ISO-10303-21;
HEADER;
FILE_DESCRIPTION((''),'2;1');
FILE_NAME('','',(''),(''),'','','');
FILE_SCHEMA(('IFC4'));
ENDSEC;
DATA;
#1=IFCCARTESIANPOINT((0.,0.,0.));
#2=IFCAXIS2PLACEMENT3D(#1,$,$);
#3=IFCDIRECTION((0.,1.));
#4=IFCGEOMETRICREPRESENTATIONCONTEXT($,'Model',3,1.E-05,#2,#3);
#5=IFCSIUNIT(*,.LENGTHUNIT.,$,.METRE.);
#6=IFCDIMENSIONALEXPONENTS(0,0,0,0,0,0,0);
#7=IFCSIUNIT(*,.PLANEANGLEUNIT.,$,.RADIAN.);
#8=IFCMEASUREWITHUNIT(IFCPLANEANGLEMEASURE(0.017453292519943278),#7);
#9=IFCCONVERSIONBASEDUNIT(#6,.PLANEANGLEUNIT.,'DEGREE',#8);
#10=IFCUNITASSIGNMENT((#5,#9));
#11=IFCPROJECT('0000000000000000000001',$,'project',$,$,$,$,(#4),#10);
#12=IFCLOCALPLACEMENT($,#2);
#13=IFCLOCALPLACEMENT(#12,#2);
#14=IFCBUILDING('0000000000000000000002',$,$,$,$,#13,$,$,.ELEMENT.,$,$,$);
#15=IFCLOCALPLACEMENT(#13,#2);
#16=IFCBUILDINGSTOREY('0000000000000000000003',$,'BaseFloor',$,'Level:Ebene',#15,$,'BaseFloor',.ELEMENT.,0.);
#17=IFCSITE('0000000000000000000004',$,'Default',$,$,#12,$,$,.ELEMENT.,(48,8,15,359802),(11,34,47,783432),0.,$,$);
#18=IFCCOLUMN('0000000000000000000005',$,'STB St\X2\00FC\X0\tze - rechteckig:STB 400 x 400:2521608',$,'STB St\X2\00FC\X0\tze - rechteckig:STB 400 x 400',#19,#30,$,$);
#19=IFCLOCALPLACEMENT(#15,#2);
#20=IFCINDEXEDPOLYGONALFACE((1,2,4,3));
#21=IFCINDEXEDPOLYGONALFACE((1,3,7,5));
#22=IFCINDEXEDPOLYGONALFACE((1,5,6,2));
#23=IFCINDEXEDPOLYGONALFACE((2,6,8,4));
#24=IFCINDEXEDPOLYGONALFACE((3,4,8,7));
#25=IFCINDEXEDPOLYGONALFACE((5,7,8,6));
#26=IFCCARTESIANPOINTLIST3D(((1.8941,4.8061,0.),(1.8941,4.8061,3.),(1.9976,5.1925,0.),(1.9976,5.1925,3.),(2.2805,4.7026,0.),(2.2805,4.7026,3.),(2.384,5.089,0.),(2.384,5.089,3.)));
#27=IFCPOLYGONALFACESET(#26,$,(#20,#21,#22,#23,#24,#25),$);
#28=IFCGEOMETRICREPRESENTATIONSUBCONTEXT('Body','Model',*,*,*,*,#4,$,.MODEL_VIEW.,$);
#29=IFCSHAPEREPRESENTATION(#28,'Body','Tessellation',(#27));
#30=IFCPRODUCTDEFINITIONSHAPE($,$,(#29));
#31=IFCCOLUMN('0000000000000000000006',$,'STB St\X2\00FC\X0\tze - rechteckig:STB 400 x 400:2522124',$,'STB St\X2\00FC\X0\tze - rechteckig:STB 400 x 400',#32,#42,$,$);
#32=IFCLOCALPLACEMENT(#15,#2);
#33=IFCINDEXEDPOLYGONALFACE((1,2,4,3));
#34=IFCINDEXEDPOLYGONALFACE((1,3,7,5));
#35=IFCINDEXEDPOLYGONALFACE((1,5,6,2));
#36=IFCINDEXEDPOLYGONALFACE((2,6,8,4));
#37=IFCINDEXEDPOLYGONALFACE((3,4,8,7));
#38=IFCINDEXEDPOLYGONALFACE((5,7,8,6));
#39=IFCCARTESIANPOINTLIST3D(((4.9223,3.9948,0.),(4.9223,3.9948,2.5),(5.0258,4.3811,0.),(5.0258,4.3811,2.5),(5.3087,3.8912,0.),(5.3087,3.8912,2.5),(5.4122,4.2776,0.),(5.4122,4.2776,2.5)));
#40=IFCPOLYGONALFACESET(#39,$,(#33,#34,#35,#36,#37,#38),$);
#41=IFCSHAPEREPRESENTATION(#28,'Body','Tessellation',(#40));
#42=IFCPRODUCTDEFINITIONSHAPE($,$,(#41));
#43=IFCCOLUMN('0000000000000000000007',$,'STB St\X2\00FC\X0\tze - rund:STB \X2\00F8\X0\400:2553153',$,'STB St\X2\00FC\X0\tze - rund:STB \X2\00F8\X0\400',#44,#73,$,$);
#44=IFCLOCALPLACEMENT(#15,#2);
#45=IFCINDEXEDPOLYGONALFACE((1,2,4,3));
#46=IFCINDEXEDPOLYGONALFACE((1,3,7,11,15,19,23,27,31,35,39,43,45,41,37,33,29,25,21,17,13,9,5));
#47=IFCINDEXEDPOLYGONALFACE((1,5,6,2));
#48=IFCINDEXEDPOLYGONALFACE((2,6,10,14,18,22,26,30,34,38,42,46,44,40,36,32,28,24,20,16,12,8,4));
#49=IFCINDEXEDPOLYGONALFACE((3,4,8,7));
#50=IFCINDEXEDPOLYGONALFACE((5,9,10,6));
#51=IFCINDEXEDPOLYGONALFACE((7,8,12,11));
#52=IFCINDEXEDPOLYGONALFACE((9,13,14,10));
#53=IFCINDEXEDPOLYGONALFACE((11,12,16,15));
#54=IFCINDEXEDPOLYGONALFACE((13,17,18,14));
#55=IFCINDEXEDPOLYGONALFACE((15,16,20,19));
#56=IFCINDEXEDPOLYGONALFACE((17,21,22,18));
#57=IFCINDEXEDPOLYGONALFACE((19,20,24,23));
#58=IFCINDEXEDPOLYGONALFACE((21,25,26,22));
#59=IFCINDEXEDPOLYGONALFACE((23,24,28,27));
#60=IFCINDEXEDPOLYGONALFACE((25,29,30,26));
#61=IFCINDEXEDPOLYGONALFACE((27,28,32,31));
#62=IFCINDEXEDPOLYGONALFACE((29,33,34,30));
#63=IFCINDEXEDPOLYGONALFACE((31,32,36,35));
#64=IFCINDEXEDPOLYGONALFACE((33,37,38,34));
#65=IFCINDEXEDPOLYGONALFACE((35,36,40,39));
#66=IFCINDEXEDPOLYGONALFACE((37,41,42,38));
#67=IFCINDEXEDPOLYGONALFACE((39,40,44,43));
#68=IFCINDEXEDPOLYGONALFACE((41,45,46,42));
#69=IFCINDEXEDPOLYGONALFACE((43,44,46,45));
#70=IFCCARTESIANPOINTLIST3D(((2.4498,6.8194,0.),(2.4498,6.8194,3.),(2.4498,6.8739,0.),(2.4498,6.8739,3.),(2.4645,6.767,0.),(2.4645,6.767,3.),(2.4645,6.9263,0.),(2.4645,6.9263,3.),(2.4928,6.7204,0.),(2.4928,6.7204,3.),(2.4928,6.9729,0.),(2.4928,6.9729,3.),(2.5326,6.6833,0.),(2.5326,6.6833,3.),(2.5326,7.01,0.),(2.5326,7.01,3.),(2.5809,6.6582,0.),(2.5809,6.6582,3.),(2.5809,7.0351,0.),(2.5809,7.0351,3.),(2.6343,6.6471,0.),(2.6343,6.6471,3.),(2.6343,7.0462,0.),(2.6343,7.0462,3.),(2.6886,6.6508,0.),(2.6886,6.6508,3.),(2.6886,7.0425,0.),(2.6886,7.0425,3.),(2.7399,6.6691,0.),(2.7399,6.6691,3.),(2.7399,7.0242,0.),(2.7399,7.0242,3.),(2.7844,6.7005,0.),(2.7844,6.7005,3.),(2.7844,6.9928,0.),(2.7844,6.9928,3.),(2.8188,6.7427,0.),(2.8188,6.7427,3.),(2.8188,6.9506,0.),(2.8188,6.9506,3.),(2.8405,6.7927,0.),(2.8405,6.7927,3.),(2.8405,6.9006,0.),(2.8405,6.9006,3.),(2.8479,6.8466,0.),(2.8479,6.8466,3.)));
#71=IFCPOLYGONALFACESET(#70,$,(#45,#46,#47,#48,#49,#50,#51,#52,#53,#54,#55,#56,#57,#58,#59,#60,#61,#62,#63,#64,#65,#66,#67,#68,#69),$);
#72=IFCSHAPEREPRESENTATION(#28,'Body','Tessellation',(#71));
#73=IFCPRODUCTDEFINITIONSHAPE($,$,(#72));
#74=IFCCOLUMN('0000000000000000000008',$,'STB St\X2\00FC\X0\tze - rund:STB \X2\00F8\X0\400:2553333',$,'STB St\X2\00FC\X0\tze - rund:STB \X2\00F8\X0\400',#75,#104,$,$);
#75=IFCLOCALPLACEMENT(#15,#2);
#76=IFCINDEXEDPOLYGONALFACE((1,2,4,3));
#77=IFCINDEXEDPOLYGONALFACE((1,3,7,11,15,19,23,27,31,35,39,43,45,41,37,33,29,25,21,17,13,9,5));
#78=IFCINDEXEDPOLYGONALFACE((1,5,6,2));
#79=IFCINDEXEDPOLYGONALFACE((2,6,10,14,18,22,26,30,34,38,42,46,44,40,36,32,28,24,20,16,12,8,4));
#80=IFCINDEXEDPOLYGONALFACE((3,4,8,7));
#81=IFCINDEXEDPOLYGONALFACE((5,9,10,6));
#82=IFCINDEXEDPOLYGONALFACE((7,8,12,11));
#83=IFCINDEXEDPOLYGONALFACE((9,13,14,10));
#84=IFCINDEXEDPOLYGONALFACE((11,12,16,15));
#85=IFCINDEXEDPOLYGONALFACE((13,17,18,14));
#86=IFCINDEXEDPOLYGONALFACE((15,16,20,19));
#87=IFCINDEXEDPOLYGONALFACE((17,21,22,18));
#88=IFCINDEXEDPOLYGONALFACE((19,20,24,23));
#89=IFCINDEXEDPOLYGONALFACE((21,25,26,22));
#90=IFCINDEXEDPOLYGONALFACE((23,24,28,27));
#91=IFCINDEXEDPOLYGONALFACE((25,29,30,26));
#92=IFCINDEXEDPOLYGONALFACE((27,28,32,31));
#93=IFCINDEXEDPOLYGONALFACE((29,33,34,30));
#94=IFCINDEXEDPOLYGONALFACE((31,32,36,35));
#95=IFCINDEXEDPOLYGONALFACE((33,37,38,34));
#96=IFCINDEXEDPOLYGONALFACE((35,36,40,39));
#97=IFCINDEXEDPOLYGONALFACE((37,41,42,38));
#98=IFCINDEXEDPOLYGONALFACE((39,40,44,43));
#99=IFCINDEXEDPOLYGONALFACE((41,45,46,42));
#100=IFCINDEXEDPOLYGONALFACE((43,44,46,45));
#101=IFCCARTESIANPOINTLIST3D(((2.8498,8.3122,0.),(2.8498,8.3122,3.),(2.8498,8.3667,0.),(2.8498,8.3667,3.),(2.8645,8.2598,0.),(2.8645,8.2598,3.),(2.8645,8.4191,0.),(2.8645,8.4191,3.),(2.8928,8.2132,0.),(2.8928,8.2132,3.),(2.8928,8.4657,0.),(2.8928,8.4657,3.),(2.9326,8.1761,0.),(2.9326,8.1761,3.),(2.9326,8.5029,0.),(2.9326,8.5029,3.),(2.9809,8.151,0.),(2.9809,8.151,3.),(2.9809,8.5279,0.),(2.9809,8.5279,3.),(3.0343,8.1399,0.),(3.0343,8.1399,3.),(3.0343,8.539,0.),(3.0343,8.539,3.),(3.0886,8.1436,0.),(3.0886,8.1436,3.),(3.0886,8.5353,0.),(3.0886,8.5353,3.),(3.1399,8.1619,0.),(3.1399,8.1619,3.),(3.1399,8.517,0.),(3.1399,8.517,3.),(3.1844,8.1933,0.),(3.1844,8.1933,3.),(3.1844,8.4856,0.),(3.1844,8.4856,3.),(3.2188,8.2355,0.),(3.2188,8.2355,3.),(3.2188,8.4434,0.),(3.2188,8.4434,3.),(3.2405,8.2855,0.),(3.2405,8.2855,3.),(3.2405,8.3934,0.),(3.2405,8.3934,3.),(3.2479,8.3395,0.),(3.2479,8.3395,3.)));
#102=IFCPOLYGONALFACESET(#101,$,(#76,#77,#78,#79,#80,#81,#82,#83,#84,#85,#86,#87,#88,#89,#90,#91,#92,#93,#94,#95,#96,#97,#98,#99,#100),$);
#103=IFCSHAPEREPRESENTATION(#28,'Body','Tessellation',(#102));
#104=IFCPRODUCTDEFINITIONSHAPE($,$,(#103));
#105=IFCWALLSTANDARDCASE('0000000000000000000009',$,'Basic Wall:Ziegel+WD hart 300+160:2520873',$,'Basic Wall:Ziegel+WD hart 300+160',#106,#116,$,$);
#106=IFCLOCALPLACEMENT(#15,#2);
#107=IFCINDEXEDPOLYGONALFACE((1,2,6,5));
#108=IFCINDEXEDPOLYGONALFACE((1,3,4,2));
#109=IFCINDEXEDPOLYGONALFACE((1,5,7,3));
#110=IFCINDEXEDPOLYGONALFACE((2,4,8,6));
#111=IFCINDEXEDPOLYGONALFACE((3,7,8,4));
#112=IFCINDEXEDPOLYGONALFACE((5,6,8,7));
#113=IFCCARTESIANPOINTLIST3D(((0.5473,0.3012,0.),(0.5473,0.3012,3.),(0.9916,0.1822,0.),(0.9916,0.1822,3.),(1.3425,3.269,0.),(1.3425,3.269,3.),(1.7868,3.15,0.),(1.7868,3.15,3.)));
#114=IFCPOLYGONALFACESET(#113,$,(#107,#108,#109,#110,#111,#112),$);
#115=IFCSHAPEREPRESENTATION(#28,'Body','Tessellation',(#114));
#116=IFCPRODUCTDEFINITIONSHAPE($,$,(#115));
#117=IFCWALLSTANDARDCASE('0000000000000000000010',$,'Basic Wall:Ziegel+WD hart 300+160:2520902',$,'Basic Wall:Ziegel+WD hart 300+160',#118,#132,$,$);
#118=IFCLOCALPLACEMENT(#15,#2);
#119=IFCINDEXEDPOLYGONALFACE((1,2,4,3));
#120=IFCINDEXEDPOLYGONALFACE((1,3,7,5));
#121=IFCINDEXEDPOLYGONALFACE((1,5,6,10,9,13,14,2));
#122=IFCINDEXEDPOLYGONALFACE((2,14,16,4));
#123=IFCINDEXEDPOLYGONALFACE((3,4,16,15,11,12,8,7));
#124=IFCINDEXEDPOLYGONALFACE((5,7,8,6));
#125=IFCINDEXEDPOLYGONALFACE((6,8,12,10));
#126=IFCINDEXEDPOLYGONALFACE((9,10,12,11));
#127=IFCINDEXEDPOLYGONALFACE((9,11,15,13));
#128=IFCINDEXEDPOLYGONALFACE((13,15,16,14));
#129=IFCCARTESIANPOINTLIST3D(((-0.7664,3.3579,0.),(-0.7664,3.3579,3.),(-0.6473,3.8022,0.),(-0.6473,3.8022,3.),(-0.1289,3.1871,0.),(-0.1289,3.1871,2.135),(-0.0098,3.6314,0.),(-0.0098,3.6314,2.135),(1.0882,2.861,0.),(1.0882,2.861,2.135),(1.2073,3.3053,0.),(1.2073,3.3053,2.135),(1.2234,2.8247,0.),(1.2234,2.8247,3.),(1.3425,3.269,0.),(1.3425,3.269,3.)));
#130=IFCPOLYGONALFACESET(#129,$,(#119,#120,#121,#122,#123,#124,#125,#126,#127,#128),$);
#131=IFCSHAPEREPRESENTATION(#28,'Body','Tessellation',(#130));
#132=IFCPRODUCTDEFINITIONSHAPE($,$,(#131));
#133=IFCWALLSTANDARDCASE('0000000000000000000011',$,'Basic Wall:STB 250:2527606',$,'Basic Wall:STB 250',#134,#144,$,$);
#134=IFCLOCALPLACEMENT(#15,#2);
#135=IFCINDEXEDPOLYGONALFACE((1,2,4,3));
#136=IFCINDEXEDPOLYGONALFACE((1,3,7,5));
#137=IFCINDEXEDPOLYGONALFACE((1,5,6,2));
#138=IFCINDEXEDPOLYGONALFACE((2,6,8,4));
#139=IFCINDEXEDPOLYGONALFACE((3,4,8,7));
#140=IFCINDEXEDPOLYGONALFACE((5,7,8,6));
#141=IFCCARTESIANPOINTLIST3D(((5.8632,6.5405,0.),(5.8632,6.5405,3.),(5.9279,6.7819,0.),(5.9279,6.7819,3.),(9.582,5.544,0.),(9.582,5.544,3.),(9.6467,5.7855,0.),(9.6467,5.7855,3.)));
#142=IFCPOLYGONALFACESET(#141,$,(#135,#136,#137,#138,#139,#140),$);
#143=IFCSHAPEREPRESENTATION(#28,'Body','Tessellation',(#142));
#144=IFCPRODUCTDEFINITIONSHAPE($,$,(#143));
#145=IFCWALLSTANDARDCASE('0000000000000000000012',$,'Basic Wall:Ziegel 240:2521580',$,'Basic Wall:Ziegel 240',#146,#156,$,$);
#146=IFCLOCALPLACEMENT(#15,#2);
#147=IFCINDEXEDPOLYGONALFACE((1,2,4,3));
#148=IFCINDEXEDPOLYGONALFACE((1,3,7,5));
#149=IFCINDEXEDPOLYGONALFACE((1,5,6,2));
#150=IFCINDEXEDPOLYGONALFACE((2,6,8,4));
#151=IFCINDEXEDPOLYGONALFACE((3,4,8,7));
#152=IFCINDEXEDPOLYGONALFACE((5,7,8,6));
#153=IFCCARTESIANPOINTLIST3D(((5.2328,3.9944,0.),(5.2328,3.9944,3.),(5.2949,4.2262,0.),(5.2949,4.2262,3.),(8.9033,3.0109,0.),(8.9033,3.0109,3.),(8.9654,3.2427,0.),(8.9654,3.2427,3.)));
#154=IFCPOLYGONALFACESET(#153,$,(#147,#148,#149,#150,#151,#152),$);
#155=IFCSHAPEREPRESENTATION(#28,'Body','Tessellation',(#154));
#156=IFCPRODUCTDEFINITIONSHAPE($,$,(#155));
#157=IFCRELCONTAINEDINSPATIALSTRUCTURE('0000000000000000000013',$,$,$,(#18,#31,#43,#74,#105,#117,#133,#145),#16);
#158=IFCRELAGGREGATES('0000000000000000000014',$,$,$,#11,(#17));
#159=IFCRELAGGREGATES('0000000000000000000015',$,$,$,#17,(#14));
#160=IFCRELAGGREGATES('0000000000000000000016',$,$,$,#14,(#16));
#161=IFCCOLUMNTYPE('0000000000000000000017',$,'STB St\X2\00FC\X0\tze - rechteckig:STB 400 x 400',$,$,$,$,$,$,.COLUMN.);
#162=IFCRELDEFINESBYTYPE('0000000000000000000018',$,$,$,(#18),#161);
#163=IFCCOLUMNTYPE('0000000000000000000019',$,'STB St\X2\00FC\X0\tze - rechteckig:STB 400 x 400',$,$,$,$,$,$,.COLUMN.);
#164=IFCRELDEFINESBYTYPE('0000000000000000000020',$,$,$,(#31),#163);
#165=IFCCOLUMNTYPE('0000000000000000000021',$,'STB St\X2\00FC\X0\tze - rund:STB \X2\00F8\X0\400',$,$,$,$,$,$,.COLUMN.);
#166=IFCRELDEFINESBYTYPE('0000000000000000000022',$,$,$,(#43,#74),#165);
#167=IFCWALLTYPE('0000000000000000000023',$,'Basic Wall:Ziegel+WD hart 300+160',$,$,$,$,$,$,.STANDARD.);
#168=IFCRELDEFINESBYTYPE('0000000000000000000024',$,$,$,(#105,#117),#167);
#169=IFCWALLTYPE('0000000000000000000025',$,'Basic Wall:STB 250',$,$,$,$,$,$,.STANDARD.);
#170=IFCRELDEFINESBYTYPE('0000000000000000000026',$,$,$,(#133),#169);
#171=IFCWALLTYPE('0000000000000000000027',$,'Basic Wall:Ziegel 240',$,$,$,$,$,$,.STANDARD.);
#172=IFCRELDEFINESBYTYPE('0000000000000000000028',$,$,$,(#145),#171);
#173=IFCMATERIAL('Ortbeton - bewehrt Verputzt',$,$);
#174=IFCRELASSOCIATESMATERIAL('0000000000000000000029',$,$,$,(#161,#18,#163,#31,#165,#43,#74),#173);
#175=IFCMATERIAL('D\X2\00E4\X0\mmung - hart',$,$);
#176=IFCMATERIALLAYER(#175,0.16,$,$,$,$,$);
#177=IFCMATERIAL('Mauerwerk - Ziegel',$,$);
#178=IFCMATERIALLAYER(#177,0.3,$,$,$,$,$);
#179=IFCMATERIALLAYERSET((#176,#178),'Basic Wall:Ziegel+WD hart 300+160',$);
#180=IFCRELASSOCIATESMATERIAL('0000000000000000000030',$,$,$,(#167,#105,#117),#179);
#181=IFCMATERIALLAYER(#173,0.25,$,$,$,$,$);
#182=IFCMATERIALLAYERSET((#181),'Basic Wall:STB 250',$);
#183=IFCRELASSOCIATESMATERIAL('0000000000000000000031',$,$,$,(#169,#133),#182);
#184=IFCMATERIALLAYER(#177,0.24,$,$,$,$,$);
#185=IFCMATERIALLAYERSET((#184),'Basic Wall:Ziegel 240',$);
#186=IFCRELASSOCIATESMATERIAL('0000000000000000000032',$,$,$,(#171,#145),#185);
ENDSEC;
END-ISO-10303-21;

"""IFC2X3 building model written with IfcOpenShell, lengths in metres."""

from ifc_helpers import new_model, entity, si_unit, converted_unit, direction, frame, frame_2d, origin, origin_2d_with_axis, place, context, subcontext, project, spatial, rectangle, circle, extrude, source, transform, mapped, material, layer, layer_set, layer_usage, type_object, type_shapes, element, save


model = new_model("IFC2X3")

# Units and contexts
model_context = context("Model", 3, precision=1e-05, world=origin(), true_north=direction((0.0, 1.0)))
body_context = subcontext(model_context, "Body", "Model", "MODEL_VIEW")
ifc_project = project(units=[si_unit("LENGTHUNIT", "METRE"), converted_unit("PLANEANGLEUNIT", "DEGREE", entity("IfcPlaneAngleMeasure", 0.017453292519943278), si_unit("PLANEANGLEUNIT", "RADIAN"), dimensions=[0, 0, 0, 0, 0, 0, 0])], contexts=[model_context])

# Site, building, storey
site_placement = place(None, origin())
site = spatial("IfcSite", under=ifc_project, at=site_placement, Name="Default", CompositionType="ELEMENT", RefLatitude=(48, 8, 15, 359802), RefLongitude=(11, 34, 47, 783432), RefElevation=0.0)
building_placement = place(site_placement, origin())
building = spatial("IfcBuilding", under=site, at=building_placement, CompositionType="ELEMENT")
storey_placement = place(building_placement, origin())
storey = spatial("IfcBuildingStorey", under=building, at=storey_placement, Name="BaseFloor", ObjectType="Level:Ebene", LongName="BaseFloor", CompositionType="ELEMENT", Elevation=0.0)

# Columns
ifc_material_1 = material(Name="Ortbeton - bewehrt Verputzt")
column_type_1 = type_object("IfcColumnType", Name="STB Stütze - rechteckig:STB 400 x 400", PredefinedType="COLUMN", material=ifc_material_1)
shared_shape_1 = source(origin(), body_context, "Body", "SweptSolid", [
    extrude(rectangle(XDim=0.4, YDim=0.4, at=frame_2d((0.0, 0.0), x_axis=(1.0, 0.0))), frame((2.1391, 4.9476, 0.0), z_axis=(0.0, 0.0, 1.0), x_axis=(-0.258819, -0.965926, 0.0)), (0.0, 0.0, 1.0), 3.0),
])
type_shapes(column_type_1, [shared_shape_1])
column_1_placement = place(storey_placement, origin())
element("IfcColumn", 1, at=column_1_placement, inside=storey, type_object=column_type_1, material=ifc_material_1, Name="STB Stütze - rechteckig:STB 400 x 400:2521608", ObjectType="STB Stütze - rechteckig:STB 400 x 400", context=body_context, shape_type="MappedRepresentation", body=[
    mapped(shared_shape_1, transform((0.0, 0.0, 0.0), scale=1.0)),
])
column_type_2 = type_object("IfcColumnType", Name="STB Stütze - rechteckig:STB 400 x 400", PredefinedType="COLUMN", material=ifc_material_1)
shared_shape_2 = source(origin(), body_context, "Body", "SweptSolid", [
    extrude(rectangle(XDim=0.4, YDim=0.4, at=origin_2d_with_axis()), frame((0.0, 0.0, 0.0), z_axis=(0.0, 0.0, 1.0), x_axis=(-1.0, 0.0, 0.0)), (0.0, 0.0, 1.0), 2.5),
])
type_shapes(column_type_2, [shared_shape_2])
column_2_placement = place(storey_placement, frame((5.1672, 4.1362, 0.0), z_axis=(0.0, 0.0, 1.0), x_axis=(0.258819, 0.965926, 0.0)))
element("IfcColumn", 2, at=column_2_placement, inside=storey, type_object=column_type_2, material=ifc_material_1, Name="STB Stütze - rechteckig:STB 400 x 400:2522124", ObjectType="STB Stütze - rechteckig:STB 400 x 400", context=body_context, shape_type="MappedRepresentation", body=[
    mapped(shared_shape_2, transform((0.0, 0.0, 0.0), scale=1.0)),
])
column_type_3 = type_object("IfcColumnType", Name="STB Stütze - rund:STB ø400", PredefinedType="COLUMN", material=ifc_material_1)
shared_shape_3 = source(origin(), body_context, "Body", "SweptSolid", [
    extrude(circle(Radius=0.2, at=frame_2d((0.0, 0.0), x_axis=(1.0, 0.0))), origin(), (0.0, 0.0, 1.0), 3.0),
])
type_shapes(column_type_3, [shared_shape_3])
for number, where, name in (
    (3, (2.6479, 6.8466, 0.0), "STB Stütze - rund:STB ø400:2553153"),
    (4, (3.0479, 8.3395, 0.0), "STB Stütze - rund:STB ø400:2553333"),
):
    element("IfcColumn", number, at=place(storey_placement, frame(where)), inside=storey, type_object=column_type_3, material=ifc_material_1, Name=name, ObjectType="STB Stütze - rund:STB ø400", context=body_context, shape_type="MappedRepresentation", body=[
        mapped(shared_shape_3, transform((0.0, 0.0, 0.0), scale=1.0)),
    ])

# Wall
ifc_material_2 = material(Name="Dämmung - hart")
ifc_layer_1 = layer(ifc_material_2, 0.16)
ifc_material_3 = material(Name="Mauerwerk - Ziegel")
ifc_layer_2 = layer(ifc_material_3, 0.3)
ifc_layer_set_1 = layer_set([ifc_layer_1, ifc_layer_2], Name="Basic Wall:Ziegel+WD hart 300+160")
ifc_layer_usage_1 = layer_usage(ifc_layer_set_1, "AXIS2", "NEGATIVE", 0.23)
wall_type_1 = type_object("IfcWallType", Name="Basic Wall:Ziegel+WD hart 300+160", PredefinedType="STANDARD", material=ifc_layer_set_1)
wall_1_placement = place(storey_placement, frame((0.7694, 0.2417, 0.0), z_axis=(0.0, 0.0, 1.0), x_axis=(0.258819, 0.965926, 0.0)))
element("IfcWallStandardCase", 5, at=wall_1_placement, inside=storey, type_object=wall_type_1, material=ifc_layer_usage_1, Name="Basic Wall:Ziegel+WD hart 300+160:2520873", ObjectType="Basic Wall:Ziegel+WD hart 300+160", context=body_context, shape_type="SweptSolid", body=[
    extrude(rectangle(XDim=3.0725, YDim=0.46, at=frame_2d((1.5363, 0.0), x_axis=(-1.0, 0.0))), origin(), (0.0, 0.0, 1.0), 3.0),
])

# Wall, opening
ifc_layer_usage_2 = layer_usage(ifc_layer_set_1, "AXIS2", "NEGATIVE", 0.23)
wall_2_placement = place(storey_placement, frame((1.283, 3.0469, 0.0), z_axis=(0.0, 0.0, 1.0), x_axis=(-0.965926, 0.258819, 0.0)))
wall_2 = element("IfcWallStandardCase", 6, at=wall_2_placement, inside=storey, type_object=wall_type_1, material=ifc_layer_usage_2, Name="Basic Wall:Ziegel+WD hart 300+160:2520902", ObjectType="Basic Wall:Ziegel+WD hart 300+160", context=body_context, shape_type="SweptSolid", body=[
    extrude(rectangle(XDim=2.06, YDim=0.46, at=frame_2d((1.03, 0.0), x_axis=(1.0, 0.0))), origin(), (0.0, 0.0, 1.0), 3.0),
])
opening_1_placement = place(wall_2_placement, frame((1.4, 0.23, -0.18)))
element("IfcOpeningElement", 7, at=opening_1_placement, cuts=wall_2, ObjectType="Opening", context=body_context, shape_type="SweptSolid", body=[
    extrude(rectangle(XDim=2.315, YDim=1.26, at=frame_2d((1.1575, 0.63), x_axis=(-1.0, 0.0))), frame((0.0, 0.0, 0.0), z_axis=(0.0, -1.0, 0.0), x_axis=(0.0, 0.0, 1.0)), (0.0, 0.0, 1.0), 0.46),
])
ifc_layer_3 = layer(ifc_material_1, 0.25)
ifc_layer_set_2 = layer_set([ifc_layer_3], Name="Basic Wall:STB 250")
wall_type_2 = type_object("IfcWallType", Name="Basic Wall:STB 250", PredefinedType="STANDARD", material=ifc_layer_set_2)

# Walls
ifc_layer_usage_3 = layer_usage(ifc_layer_set_2, "AXIS2", "NEGATIVE", 0.125)
wall_3_placement = place(storey_placement, frame((5.8956, 6.6612, 0.0), z_axis=(0.0, 0.0, 1.0), x_axis=(0.965926, -0.258819, 0.0)))
element("IfcWallStandardCase", 8, at=wall_3_placement, inside=storey, type_object=wall_type_2, material=ifc_layer_usage_3, Name="Basic Wall:STB 250:2527606", ObjectType="Basic Wall:STB 250", context=body_context, shape_type="SweptSolid", body=[
    extrude(rectangle(XDim=3.85, YDim=0.25, at=frame_2d((1.925, 0.0), x_axis=(-1.0, 0.0))), origin(), (0.0, 0.0, 1.0), 3.0),
])
ifc_layer_4 = layer(ifc_material_3, 0.24)
ifc_layer_set_3 = layer_set([ifc_layer_4], Name="Basic Wall:Ziegel 240")
ifc_layer_usage_4 = layer_usage(ifc_layer_set_3, "AXIS2", "NEGATIVE", 0.12)
wall_type_3 = type_object("IfcWallType", Name="Basic Wall:Ziegel 240", PredefinedType="STANDARD", material=ifc_layer_set_3)
wall_4_placement = place(storey_placement, frame((8.9343, 3.1268, 0.0), z_axis=(0.0, 0.0, 1.0), x_axis=(-0.965926, 0.258819, 0.0)))
element("IfcWallStandardCase", 9, at=wall_4_placement, inside=storey, type_object=wall_type_3, material=ifc_layer_usage_4, Name="Basic Wall:Ziegel 240:2521580", ObjectType="Basic Wall:Ziegel 240", context=body_context, shape_type="SweptSolid", body=[
    extrude(rectangle(XDim=3.8, YDim=0.24, at=frame_2d((1.9, 0.0), x_axis=(-1.0, 0.0))), origin(), (0.0, 0.0, 1.0), 3.0),
])

save(model, "model.ifc")
